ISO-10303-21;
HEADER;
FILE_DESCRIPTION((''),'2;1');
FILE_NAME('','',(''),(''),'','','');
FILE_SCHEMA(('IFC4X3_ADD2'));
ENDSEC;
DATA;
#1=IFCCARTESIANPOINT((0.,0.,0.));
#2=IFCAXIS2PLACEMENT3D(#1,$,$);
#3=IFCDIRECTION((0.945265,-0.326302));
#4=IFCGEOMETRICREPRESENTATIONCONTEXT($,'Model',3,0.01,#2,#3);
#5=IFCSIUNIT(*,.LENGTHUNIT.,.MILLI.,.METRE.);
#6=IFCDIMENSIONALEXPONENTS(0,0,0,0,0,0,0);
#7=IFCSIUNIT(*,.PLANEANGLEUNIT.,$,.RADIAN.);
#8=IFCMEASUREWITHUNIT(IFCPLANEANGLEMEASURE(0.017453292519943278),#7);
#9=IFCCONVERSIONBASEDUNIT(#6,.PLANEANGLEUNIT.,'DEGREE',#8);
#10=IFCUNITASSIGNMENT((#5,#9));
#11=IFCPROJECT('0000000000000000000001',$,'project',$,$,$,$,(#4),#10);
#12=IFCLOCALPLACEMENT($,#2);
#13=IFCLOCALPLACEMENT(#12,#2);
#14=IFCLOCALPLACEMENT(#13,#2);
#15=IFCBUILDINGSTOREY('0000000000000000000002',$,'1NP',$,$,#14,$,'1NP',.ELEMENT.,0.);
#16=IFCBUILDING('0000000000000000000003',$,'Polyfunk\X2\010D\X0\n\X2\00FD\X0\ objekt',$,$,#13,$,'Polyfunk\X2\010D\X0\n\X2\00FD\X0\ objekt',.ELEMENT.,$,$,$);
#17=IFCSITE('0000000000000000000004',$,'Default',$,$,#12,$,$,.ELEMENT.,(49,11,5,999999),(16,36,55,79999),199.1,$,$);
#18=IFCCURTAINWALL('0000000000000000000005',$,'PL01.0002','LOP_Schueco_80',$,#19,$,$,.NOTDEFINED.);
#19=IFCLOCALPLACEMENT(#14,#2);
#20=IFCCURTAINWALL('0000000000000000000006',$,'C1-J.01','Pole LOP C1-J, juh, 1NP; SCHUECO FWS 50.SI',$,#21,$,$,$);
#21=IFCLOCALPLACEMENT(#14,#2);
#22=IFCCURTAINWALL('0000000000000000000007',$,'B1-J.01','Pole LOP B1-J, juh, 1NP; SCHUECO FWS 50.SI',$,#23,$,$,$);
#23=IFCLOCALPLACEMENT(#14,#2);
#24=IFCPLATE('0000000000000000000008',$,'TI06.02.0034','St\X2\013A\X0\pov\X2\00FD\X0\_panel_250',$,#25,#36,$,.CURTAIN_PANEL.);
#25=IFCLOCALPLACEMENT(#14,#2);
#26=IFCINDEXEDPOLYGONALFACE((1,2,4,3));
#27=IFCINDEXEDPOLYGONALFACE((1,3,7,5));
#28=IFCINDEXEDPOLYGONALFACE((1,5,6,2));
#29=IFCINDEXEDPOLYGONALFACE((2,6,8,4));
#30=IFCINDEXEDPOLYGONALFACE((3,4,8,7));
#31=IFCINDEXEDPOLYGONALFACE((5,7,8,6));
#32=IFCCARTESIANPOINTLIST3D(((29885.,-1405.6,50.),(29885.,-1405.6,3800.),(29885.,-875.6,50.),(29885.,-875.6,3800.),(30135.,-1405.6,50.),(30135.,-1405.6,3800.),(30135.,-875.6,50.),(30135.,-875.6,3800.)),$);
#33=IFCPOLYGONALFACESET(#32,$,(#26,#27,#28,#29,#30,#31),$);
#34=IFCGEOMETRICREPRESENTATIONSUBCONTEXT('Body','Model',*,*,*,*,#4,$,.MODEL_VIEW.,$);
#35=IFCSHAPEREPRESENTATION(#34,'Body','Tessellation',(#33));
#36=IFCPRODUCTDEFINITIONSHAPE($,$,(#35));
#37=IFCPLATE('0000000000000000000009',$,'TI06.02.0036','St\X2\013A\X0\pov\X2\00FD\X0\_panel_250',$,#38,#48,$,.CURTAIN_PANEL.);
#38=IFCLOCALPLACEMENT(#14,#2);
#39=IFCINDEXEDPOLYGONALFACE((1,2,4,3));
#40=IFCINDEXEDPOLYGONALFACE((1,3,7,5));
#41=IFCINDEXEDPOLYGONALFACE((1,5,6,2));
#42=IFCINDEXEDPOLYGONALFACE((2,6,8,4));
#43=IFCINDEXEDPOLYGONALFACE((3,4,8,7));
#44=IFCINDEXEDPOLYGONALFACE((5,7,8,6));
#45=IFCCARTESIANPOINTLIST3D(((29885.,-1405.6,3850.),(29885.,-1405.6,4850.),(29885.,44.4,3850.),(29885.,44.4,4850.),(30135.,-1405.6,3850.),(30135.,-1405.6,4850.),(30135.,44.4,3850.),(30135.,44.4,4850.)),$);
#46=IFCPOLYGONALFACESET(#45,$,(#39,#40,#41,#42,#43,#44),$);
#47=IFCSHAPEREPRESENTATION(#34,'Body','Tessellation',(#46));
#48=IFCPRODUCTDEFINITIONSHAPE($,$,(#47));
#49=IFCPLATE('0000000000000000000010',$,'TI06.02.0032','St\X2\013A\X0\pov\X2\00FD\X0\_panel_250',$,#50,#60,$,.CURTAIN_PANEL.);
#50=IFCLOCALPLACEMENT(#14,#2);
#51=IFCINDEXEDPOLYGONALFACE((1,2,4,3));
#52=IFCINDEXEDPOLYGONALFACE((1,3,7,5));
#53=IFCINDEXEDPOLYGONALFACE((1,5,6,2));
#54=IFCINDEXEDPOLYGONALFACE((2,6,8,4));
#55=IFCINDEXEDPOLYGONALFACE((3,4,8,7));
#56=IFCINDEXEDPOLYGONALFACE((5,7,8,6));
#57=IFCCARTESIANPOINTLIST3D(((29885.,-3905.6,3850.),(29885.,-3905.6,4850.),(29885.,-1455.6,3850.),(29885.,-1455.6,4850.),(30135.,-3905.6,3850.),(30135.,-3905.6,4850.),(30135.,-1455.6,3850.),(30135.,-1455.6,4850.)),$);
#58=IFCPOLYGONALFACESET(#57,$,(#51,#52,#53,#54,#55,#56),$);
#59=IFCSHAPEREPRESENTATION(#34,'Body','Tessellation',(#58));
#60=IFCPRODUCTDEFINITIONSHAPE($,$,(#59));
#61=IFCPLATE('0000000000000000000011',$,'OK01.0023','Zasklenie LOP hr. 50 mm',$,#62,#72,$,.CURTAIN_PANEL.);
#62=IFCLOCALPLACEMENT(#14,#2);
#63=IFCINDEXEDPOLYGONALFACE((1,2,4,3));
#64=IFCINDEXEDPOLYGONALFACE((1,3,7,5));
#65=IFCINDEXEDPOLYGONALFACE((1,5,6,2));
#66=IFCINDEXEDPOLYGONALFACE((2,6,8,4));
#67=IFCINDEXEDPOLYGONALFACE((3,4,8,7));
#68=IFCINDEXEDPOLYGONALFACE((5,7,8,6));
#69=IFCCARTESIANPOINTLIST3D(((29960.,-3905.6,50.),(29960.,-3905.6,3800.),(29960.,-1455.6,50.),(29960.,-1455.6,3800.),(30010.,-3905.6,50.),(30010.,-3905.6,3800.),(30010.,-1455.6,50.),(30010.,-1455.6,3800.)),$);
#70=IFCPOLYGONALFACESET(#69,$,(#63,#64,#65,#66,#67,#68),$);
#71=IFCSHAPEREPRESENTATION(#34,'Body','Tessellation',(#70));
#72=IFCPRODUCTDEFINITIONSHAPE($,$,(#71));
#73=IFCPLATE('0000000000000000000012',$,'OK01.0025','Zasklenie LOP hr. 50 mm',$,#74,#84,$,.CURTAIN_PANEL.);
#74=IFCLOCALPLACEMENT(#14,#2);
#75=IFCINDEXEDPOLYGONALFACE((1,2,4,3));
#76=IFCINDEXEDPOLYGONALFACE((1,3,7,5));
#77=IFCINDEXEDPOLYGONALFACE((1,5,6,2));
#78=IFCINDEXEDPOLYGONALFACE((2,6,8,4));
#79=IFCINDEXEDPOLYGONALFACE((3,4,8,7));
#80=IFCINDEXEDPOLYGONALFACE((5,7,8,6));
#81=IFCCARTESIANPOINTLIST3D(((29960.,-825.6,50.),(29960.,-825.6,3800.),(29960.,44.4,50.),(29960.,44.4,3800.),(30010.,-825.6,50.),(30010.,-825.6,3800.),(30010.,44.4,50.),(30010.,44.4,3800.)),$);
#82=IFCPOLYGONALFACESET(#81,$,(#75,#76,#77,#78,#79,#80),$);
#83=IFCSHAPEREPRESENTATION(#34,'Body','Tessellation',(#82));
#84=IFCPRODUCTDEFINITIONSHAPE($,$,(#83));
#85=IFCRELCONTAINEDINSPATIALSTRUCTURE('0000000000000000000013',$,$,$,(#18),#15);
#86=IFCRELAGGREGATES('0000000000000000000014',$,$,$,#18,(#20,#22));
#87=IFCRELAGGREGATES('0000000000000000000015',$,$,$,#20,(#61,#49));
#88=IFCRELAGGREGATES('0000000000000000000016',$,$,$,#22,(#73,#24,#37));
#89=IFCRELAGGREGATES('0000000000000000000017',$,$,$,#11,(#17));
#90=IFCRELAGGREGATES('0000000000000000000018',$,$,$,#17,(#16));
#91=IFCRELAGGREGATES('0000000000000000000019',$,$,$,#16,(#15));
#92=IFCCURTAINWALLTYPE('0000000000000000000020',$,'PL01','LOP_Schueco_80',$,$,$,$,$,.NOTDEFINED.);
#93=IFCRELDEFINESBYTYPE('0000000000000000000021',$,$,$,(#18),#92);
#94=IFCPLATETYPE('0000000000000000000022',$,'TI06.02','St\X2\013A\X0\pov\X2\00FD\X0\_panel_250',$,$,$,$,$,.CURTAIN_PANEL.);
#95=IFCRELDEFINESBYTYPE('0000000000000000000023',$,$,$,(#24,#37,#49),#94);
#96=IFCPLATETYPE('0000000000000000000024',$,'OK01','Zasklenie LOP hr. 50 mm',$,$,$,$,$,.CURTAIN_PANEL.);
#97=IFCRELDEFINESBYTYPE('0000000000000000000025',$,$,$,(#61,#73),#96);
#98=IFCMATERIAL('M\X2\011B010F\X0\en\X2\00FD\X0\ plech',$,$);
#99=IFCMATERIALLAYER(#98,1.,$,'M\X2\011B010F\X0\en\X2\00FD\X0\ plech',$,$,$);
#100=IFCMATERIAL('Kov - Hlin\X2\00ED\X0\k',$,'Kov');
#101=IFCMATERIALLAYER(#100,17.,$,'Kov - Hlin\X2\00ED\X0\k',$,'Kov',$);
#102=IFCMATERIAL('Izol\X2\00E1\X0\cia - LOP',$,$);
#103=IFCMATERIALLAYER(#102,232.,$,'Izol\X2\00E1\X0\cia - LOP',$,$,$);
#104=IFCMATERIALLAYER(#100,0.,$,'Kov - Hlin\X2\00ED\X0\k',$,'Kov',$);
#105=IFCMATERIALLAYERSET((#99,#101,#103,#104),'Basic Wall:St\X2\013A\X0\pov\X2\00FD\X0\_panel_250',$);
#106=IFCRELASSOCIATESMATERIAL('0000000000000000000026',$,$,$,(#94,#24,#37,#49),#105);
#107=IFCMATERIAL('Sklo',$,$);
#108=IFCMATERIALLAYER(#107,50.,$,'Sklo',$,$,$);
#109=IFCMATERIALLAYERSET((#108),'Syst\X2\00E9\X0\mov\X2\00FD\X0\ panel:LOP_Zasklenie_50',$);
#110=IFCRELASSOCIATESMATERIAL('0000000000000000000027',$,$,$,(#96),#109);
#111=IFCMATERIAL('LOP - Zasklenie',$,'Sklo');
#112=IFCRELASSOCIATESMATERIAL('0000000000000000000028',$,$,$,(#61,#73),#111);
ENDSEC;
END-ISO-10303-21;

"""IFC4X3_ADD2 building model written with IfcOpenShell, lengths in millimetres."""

from ifc_helpers import new_model, entity, si_unit, converted_unit, direction, frame, frame_2d, origin, place, context, subcontext, project, spatial, rectangle, extrude, source, transform, mapped, material, layer, layer_set, layer_usage, type_object, type_shapes, element, aggregate, save


model = new_model("IFC4X3_ADD2")

# Units and contexts
model_context = context("Model", 3, precision=0.01, world=origin(), true_north=direction((0.945265, -0.326302)))
body_context = subcontext(model_context, "Body", "Model", "MODEL_VIEW")
ifc_project = project(units=[si_unit("LENGTHUNIT", "METRE", prefix="MILLI"), converted_unit("PLANEANGLEUNIT", "DEGREE", entity("IfcPlaneAngleMeasure", 0.017453292519943278), si_unit("PLANEANGLEUNIT", "RADIAN"), dimensions=[0, 0, 0, 0, 0, 0, 0])], contexts=[model_context])

# Site, building, storey
site_placement = place(None, origin())
site = spatial("IfcSite", under=ifc_project, at=site_placement, Name="Default", CompositionType="ELEMENT", RefLatitude=(49, 11, 5, 999999), RefLongitude=(16, 36, 55, 79999), RefElevation=199.1)
building_placement = place(site_placement, origin())
building = spatial("IfcBuilding", under=site, at=building_placement, Name="Polyfunkčný objekt", LongName="Polyfunkčný objekt", CompositionType="ELEMENT")
storey_placement = place(building_placement, origin())
storey = spatial("IfcBuildingStorey", under=building, at=storey_placement, Name="1NP", LongName="1NP", CompositionType="ELEMENT", Elevation=0.0)

# Curtain walls, plates
curtain_wall_type = type_object("IfcCurtainWallType", Name="PL01", Description="LOP_Schueco_80", PredefinedType="NOTDEFINED")
curtain_wall_1_placement = place(storey_placement, origin())
curtain_wall_1 = element("IfcCurtainWall", 1, at=curtain_wall_1_placement, inside=storey, type_object=curtain_wall_type, Name="PL01.0002", Description="LOP_Schueco_80", PredefinedType="NOTDEFINED")
curtain_wall_2 = element("IfcCurtainWall", 2, Name="C1-J.01", Description="Pole LOP C1-J, juh, 1NP; SCHUECO FWS 50.SI")
curtain_wall_3 = element("IfcCurtainWall", 3, Name="B1-J.01", Description="Pole LOP B1-J, juh, 1NP; SCHUECO FWS 50.SI")
aggregate(curtain_wall_1, [curtain_wall_2, curtain_wall_3])
ifc_material_1 = material(Name="Měďený plech")
ifc_layer_1 = layer(ifc_material_1, 1.0, Name="Měďený plech")
ifc_material_2 = material(Name="Kov - Hliník", Category="Kov")
ifc_layer_2 = layer(ifc_material_2, 17.0, Name="Kov - Hliník", Category="Kov")
ifc_material_3 = material(Name="Izolácia - LOP")
ifc_layer_3 = layer(ifc_material_3, 232.0, Name="Izolácia - LOP")
ifc_layer_4 = layer(ifc_material_2, 0.0, Name="Kov - Hliník", Category="Kov")
ifc_layer_set_1 = layer_set([ifc_layer_1, ifc_layer_2, ifc_layer_3, ifc_layer_4], Name="Basic Wall:Stĺpový_panel_250")
ifc_layer_usage_1 = layer_usage(ifc_layer_set_1, "AXIS2", "POSITIVE", -125.0)
plate_type_1 = type_object("IfcPlateType", Name="TI06.02", Description="Stĺpový_panel_250", PredefinedType="CURTAIN_PANEL", material=ifc_layer_set_1)
plate_1_placement = place(storey_placement, frame((30010.0, -875.6, 50.0), z_axis=(0.0, 0.0, 1.0), x_axis=(0.0, -1.0, 0.0)))
plate_1 = element("IfcPlate", 4, at=plate_1_placement, type_object=plate_type_1, material=ifc_layer_usage_1, Name="TI06.02.0034", Description="Stĺpový_panel_250", PredefinedType="CURTAIN_PANEL", context=body_context, shape_type="SweptSolid", body=[
    extrude(rectangle(XDim=250.0, YDim=530.0, at=frame_2d((0.0, 0.0), x_axis=(1.0, 0.0))), frame((265.0, 0.0, 0.0), z_axis=(0.0, 0.0, 1.0), x_axis=(0.0, 1.0, 0.0)), (0.0, 0.0, 1.0), 3750.0),
])
ifc_layer_usage_2 = layer_usage(ifc_layer_set_1, "AXIS2", "POSITIVE", -125.0)
plate_2_placement = place(storey_placement, frame((30010.0, 44.4, 3850.0), z_axis=(0.0, 0.0, 1.0), x_axis=(0.0, -1.0, 0.0)))
plate_2 = element("IfcPlate", 5, at=plate_2_placement, type_object=plate_type_1, material=ifc_layer_usage_2, Name="TI06.02.0036", Description="Stĺpový_panel_250", PredefinedType="CURTAIN_PANEL", context=body_context, shape_type="SweptSolid", body=[
    extrude(rectangle(XDim=250.0, YDim=1450.0, at=frame_2d((0.0, 0.0), x_axis=(1.0, 0.0))), frame((725.0, 0.0, 0.0), z_axis=(0.0, 0.0, 1.0), x_axis=(0.0, 1.0, 0.0)), (0.0, 0.0, 1.0), 1000.0),
])
ifc_layer_usage_3 = layer_usage(ifc_layer_set_1, "AXIS2", "POSITIVE", -125.0)
plate_3_placement = place(storey_placement, frame((30010.0, -1455.6, 3850.0), z_axis=(0.0, 0.0, 1.0), x_axis=(0.0, -1.0, 0.0)))
plate_3 = element("IfcPlate", 6, at=plate_3_placement, type_object=plate_type_1, material=ifc_layer_usage_3, Name="TI06.02.0032", Description="Stĺpový_panel_250", PredefinedType="CURTAIN_PANEL", context=body_context, shape_type="SweptSolid", body=[
    extrude(rectangle(XDim=250.0, YDim=2450.0, at=frame_2d((0.0, 0.0), x_axis=(1.0, 0.0))), frame((1225.0, 0.0, 0.0), z_axis=(0.0, 0.0, 1.0), x_axis=(0.0, 1.0, 0.0)), (0.0, 0.0, 1.0), 1000.0),
])
ifc_material_4 = material(Name="LOP - Zasklenie", Category="Sklo")
ifc_material_5 = material(Name="Sklo")
ifc_layer_5 = layer(ifc_material_5, 50.0, Name="Sklo")
ifc_layer_set_2 = layer_set([ifc_layer_5], Name="Systémový panel:LOP_Zasklenie_50")
plate_type_2 = type_object("IfcPlateType", Name="OK01", Description="Zasklenie LOP hr. 50 mm", PredefinedType="CURTAIN_PANEL", material=ifc_layer_set_2)
shared_shape_1 = source(origin(), body_context, "Body", "SweptSolid", [
    extrude(rectangle(XDim=3750.0, YDim=2450.0, at=frame_2d((-141.7, 0.0), x_axis=(1.0, 0.0))), frame((0.0, -50.0, 2016.7), z_axis=(0.0, 1.0, 0.0), x_axis=(0.0, 0.0, 1.0)), (0.0, 0.0, 1.0), 50.0),
])
plate_4_placement = place(curtain_wall_1_placement, frame((30010.0, -2680.6, 50.0), z_axis=(0.0, 0.0, 1.0), x_axis=(0.0, -1.0, 0.0)))
plate_4 = element("IfcPlate", 7, at=plate_4_placement, type_object=plate_type_2, material=ifc_material_4, Name="OK01.0023", Description="Zasklenie LOP hr. 50 mm", PredefinedType="CURTAIN_PANEL", context=body_context, shape_type="MappedRepresentation", body=[
    mapped(shared_shape_1, transform((0.0, 0.0, 0.0), scale=1.0)),
])
aggregate(curtain_wall_2, [plate_4, plate_3])
shared_shape_2 = source(origin(), body_context, "Body", "SweptSolid", [
    extrude(rectangle(XDim=3750.0, YDim=870.0, at=frame_2d((-141.7, 0.0), x_axis=(1.0, 0.0))), frame((0.0, -50.0, 2016.7), z_axis=(0.0, 1.0, 0.0), x_axis=(0.0, 0.0, 1.0)), (0.0, 0.0, 1.0), 50.0),
])
type_shapes(plate_type_2, [shared_shape_1, shared_shape_2])
plate_5_placement = place(curtain_wall_1_placement, frame((30010.0, -390.6, 50.0), z_axis=(0.0, 0.0, 1.0), x_axis=(0.0, -1.0, 0.0)))
plate_5 = element("IfcPlate", 8, at=plate_5_placement, type_object=plate_type_2, material=ifc_material_4, Name="OK01.0025", Description="Zasklenie LOP hr. 50 mm", PredefinedType="CURTAIN_PANEL", context=body_context, shape_type="MappedRepresentation", body=[
    mapped(shared_shape_2, transform((0.0, 0.0, 0.0), scale=1.0)),
])
aggregate(curtain_wall_3, [plate_5, plate_1, plate_2])

save(model, "model.ifc")
